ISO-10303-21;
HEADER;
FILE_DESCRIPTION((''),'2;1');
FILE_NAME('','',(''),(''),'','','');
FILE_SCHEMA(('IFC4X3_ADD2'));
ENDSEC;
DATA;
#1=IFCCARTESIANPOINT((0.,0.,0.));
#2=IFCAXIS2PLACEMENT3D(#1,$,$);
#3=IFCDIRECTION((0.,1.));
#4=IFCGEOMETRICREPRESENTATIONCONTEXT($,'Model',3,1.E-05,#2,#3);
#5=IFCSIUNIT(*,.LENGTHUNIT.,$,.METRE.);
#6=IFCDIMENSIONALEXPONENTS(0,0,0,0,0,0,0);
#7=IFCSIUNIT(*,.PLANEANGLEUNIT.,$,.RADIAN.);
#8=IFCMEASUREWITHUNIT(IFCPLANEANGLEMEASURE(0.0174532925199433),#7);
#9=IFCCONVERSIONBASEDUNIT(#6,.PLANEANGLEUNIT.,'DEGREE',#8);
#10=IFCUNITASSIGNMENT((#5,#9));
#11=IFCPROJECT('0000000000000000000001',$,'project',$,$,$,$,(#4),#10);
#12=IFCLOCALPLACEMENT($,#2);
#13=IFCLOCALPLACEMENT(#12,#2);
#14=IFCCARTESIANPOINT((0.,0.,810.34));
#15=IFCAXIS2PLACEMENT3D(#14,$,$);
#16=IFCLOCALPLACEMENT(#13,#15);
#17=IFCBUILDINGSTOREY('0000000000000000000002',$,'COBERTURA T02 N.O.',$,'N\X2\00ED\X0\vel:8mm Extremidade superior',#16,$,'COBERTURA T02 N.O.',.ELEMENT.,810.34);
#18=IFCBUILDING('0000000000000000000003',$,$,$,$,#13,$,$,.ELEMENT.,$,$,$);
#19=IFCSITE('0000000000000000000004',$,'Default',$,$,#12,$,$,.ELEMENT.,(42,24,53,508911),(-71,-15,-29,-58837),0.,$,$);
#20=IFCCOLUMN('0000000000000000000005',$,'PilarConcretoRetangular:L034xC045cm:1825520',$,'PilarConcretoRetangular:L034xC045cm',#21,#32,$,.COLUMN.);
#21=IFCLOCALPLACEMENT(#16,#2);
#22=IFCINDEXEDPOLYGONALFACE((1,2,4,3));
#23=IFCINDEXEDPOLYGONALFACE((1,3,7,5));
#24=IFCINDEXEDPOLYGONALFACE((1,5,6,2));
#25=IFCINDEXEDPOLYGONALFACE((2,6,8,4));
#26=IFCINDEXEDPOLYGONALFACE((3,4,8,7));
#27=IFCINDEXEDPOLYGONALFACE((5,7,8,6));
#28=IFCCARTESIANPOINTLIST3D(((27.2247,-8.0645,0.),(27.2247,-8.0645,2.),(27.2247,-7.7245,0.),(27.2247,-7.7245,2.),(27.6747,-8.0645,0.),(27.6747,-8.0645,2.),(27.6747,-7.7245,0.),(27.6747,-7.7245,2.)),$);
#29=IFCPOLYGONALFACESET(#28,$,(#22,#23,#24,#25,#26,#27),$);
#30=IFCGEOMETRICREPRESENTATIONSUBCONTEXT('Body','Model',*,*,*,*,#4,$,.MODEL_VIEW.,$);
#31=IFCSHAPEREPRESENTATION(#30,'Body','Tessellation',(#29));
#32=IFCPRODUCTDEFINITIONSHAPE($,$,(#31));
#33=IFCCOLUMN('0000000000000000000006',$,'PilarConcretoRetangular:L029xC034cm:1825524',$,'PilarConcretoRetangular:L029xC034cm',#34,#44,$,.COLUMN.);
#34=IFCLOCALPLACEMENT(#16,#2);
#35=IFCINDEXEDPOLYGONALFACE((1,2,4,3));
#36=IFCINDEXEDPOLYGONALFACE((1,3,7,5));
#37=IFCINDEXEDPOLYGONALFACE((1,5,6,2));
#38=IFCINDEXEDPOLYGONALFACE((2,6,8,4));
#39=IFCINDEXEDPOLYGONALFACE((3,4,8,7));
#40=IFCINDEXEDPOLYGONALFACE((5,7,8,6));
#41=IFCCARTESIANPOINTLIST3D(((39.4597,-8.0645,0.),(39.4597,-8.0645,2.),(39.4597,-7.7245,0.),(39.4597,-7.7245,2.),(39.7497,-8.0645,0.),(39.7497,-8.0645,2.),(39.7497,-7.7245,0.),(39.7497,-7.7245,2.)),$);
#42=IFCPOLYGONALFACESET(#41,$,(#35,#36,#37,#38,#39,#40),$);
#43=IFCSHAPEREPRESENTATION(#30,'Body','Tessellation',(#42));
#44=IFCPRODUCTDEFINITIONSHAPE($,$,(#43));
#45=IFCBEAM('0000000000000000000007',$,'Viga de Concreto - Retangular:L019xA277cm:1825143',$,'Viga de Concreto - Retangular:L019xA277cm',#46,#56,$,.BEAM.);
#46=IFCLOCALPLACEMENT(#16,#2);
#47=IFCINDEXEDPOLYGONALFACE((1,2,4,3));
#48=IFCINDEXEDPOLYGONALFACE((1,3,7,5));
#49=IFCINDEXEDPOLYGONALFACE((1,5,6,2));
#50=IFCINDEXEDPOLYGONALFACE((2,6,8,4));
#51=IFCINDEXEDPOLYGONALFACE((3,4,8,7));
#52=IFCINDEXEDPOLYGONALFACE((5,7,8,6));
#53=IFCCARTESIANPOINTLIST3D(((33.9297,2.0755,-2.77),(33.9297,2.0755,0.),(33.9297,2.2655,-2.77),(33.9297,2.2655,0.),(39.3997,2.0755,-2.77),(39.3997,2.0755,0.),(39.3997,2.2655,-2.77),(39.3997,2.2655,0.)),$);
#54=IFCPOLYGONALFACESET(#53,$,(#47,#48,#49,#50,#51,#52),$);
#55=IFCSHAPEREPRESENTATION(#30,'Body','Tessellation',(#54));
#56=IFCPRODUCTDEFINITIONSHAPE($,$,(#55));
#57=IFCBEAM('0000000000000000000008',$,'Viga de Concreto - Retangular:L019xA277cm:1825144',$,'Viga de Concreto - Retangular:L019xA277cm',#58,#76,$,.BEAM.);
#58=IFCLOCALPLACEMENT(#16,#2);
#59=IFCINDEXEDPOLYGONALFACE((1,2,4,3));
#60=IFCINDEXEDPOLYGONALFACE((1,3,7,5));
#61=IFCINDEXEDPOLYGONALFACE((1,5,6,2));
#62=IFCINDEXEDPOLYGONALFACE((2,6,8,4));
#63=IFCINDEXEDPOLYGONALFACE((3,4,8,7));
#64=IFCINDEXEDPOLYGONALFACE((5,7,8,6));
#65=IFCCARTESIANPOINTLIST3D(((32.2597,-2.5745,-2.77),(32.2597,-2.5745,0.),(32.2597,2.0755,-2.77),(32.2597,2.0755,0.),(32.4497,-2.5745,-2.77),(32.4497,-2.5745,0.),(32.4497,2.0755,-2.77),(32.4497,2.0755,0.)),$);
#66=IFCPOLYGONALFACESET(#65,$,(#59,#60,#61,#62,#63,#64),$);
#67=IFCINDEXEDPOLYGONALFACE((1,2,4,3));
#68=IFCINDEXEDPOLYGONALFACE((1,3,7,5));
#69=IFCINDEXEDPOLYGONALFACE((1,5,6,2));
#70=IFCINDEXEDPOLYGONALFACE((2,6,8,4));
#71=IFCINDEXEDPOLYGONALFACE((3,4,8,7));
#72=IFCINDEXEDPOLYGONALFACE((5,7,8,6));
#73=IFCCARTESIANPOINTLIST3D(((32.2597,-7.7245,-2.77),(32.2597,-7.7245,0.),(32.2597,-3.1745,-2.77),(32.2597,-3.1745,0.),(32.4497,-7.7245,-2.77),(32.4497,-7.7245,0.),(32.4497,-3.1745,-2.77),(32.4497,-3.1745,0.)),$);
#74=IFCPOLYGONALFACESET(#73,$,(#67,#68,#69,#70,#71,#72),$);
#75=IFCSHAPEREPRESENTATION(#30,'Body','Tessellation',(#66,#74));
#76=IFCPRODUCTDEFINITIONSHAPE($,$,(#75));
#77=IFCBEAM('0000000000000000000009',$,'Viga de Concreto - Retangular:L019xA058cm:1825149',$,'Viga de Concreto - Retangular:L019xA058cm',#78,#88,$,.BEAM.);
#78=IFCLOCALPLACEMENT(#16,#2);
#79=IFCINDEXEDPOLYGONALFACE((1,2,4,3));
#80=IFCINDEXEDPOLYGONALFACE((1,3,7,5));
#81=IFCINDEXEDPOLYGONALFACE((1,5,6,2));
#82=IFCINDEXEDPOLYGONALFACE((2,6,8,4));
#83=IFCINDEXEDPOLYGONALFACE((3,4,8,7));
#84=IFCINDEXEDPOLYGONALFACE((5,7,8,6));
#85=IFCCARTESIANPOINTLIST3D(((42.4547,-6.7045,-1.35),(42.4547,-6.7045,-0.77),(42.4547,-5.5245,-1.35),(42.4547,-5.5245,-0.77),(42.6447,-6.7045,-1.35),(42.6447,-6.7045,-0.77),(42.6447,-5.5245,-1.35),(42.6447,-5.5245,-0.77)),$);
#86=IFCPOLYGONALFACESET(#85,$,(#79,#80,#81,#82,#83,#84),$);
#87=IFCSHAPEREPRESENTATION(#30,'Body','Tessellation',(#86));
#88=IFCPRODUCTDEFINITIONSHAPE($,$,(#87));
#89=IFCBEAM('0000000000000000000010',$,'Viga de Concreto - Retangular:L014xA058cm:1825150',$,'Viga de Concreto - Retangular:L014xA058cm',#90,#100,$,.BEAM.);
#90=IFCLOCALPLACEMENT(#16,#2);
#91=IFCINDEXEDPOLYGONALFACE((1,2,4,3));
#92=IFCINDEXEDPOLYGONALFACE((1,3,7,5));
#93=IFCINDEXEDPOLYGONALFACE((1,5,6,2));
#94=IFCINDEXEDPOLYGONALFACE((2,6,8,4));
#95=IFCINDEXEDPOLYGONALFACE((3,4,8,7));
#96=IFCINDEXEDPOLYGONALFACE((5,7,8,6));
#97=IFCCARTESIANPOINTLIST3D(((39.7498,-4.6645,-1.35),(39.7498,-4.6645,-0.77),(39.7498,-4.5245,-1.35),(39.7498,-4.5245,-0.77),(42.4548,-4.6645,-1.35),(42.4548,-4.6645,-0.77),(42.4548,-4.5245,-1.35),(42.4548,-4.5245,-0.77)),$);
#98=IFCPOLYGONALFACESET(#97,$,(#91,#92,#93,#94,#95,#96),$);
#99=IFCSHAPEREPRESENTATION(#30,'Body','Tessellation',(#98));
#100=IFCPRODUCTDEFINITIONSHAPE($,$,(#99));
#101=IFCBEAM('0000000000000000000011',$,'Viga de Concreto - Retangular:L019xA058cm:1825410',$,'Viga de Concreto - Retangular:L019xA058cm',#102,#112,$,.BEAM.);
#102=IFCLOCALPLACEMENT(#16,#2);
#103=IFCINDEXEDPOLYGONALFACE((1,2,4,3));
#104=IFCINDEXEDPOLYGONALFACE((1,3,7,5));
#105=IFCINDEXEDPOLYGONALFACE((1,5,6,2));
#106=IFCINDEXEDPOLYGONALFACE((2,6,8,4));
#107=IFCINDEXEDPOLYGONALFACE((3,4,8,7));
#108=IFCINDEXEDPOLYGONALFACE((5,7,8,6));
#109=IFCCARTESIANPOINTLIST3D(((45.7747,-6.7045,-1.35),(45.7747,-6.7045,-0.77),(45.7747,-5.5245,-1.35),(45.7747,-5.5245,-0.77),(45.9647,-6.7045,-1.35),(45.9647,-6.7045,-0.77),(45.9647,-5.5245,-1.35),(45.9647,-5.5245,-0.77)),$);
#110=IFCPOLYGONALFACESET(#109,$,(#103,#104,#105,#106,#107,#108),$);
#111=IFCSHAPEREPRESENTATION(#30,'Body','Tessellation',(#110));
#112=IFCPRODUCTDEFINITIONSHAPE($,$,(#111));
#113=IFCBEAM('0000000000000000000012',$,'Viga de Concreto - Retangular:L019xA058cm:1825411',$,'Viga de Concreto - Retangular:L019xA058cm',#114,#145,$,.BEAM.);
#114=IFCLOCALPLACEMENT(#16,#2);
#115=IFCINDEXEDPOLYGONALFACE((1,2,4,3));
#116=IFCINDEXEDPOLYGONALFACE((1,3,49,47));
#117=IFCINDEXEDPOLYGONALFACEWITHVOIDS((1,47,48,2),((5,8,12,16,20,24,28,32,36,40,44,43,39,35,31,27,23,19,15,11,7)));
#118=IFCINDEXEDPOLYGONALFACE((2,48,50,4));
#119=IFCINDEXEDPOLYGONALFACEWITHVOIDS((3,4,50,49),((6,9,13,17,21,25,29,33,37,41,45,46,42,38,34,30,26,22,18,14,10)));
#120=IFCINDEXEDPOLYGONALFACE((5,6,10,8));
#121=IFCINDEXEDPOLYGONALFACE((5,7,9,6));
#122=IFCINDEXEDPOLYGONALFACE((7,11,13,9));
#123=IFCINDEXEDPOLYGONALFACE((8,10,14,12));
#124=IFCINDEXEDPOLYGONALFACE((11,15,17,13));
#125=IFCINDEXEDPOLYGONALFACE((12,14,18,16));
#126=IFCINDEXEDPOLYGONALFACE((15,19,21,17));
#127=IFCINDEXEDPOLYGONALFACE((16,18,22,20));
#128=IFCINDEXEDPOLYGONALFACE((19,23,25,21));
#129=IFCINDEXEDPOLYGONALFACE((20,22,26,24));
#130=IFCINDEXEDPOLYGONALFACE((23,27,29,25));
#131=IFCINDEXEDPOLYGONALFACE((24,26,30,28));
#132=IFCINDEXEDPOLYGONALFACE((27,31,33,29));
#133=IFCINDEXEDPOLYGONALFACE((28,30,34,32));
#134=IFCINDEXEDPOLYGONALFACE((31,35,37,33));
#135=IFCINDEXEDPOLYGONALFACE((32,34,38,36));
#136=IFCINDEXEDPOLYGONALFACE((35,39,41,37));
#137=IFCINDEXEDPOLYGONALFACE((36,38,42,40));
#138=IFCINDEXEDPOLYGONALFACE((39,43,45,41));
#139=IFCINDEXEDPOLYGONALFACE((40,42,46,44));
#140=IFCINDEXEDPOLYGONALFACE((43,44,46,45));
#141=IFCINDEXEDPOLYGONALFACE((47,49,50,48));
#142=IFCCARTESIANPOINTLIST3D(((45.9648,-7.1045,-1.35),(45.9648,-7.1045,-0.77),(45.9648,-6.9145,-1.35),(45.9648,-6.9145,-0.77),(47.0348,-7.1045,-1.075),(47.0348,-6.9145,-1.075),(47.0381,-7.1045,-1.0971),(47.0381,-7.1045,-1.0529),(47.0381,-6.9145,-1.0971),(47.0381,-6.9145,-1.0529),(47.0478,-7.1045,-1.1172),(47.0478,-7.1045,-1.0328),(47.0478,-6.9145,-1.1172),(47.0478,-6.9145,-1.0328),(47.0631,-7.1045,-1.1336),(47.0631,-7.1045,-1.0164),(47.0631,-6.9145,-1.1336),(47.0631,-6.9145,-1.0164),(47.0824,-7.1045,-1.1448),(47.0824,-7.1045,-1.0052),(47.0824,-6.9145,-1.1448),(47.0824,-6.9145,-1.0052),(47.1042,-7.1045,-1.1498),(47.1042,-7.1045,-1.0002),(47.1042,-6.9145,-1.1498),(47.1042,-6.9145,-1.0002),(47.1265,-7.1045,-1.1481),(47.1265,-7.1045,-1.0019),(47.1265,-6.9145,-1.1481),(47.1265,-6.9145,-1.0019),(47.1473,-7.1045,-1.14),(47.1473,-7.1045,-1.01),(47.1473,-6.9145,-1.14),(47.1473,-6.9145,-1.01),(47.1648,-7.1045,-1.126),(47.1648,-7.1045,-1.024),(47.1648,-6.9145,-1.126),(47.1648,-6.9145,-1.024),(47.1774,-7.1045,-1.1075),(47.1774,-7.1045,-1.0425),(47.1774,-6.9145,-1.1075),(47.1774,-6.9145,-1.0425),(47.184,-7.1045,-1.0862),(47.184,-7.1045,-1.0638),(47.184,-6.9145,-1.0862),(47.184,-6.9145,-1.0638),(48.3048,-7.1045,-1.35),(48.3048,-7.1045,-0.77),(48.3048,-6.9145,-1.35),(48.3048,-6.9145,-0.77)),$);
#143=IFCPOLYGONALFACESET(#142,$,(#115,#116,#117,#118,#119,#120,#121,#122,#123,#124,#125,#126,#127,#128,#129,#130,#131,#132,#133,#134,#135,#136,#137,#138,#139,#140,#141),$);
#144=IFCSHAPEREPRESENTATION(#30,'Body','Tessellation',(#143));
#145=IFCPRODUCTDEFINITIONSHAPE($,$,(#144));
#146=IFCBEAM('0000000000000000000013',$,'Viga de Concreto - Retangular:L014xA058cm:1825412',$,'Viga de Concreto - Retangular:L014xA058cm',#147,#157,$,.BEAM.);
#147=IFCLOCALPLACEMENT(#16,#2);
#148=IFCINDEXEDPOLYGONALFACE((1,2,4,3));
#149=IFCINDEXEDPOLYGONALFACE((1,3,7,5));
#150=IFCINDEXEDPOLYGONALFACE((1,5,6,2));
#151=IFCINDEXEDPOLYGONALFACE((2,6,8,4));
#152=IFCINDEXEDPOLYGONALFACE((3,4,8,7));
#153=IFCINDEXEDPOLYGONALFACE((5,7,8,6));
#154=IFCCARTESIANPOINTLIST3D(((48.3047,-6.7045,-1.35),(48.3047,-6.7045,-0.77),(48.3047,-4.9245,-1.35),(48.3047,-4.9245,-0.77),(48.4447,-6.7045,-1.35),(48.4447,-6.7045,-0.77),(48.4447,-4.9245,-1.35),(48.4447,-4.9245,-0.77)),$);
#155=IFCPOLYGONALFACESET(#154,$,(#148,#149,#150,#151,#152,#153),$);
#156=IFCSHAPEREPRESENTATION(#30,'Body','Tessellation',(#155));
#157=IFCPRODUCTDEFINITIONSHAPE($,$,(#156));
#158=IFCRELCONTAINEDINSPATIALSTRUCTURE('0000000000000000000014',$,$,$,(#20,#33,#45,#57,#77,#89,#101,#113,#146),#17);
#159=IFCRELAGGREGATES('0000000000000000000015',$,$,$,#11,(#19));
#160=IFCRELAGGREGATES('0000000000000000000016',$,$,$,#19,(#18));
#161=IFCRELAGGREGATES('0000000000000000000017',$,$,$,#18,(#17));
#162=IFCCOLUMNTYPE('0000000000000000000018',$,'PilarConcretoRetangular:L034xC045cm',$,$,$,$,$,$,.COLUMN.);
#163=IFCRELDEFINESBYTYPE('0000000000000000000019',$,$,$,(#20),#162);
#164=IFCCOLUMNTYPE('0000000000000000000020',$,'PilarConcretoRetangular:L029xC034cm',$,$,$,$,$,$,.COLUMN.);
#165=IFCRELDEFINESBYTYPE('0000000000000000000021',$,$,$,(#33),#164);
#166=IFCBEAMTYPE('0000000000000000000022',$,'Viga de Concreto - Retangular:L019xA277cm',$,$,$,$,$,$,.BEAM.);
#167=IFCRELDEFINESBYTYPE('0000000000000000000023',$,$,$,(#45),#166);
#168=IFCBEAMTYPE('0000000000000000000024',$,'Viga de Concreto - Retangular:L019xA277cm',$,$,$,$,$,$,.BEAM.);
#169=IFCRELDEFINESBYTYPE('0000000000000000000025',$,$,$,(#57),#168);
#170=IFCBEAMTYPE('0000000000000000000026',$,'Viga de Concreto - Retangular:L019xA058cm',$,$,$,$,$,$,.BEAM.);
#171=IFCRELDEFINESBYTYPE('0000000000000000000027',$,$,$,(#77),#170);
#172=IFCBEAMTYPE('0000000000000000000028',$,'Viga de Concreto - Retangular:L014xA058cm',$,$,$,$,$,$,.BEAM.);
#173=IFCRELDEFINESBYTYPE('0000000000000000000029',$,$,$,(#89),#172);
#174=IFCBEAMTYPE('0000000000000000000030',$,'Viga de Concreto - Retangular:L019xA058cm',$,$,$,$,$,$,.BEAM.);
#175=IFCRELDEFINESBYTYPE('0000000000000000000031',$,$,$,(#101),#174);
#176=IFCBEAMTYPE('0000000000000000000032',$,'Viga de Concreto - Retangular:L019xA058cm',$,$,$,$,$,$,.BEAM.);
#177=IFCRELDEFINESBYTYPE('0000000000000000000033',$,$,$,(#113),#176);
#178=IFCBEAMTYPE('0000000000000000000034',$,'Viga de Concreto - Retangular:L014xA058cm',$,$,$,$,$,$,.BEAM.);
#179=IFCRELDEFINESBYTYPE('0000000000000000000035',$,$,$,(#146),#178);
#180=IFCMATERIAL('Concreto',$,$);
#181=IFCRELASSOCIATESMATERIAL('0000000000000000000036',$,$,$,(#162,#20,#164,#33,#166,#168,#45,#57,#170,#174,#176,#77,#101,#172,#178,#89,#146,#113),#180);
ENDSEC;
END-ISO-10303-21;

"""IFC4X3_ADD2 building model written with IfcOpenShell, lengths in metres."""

from ifc_helpers import new_model, entity, si_unit, converted_unit, direction, frame, frame_2d, origin, origin_2d_with_axis, place, context, subcontext, project, spatial, polyline, segment, composite_curve, rectangle, circle, outline, extrude, boolean, source, transform, mapped, material, material_profile, profile_set, profile_usage, type_object, type_shapes, element, save


model = new_model("IFC4X3_ADD2")

# Units and contexts
model_context = context("Model", 3, precision=1e-05, world=origin(), true_north=direction((0.0, 1.0)))
body_context = subcontext(model_context, "Body", "Model", "MODEL_VIEW")
ifc_project = project(units=[si_unit("LENGTHUNIT", "METRE"), converted_unit("PLANEANGLEUNIT", "DEGREE", entity("IfcPlaneAngleMeasure", 0.0174532925199433), si_unit("PLANEANGLEUNIT", "RADIAN"), dimensions=[0, 0, 0, 0, 0, 0, 0])], contexts=[model_context])

# Site, building, storey
site_placement = place(None, origin())
site = spatial("IfcSite", under=ifc_project, at=site_placement, Name="Default", CompositionType="ELEMENT", RefLatitude=(42, 24, 53, 508911), RefLongitude=(-71, -15, -29, -58837), RefElevation=0.0)
building_placement = place(site_placement, origin())
building = spatial("IfcBuilding", under=site, at=building_placement, CompositionType="ELEMENT")
storey_placement = place(building_placement, frame((0.0, 0.0, 810.34)))
storey = spatial("IfcBuildingStorey", under=building, at=storey_placement, Name="COBERTURA T02 N.O.", ObjectType="Nível:8mm Extremidade superior", LongName="COBERTURA T02 N.O.", CompositionType="ELEMENT", Elevation=810.34)

# Columns
ifc_material = material(Name="Concreto")
ifc_material_profile_1 = material_profile(ifc_material, rectangle(XDim=0.34, YDim=0.45, at=origin_2d_with_axis()), Name="L034xC045cm")
ifc_profile_set_1 = profile_set([ifc_material_profile_1], Name="L034xC045cm")
ifc_profile_usage_1 = profile_usage(ifc_profile_set_1)
column_type_1 = type_object("IfcColumnType", Name="PilarConcretoRetangular:L034xC045cm", PredefinedType="COLUMN", material=ifc_profile_set_1)
shared_shape_1 = source(origin(), body_context, "Body", "SweptSolid", [
    extrude(rectangle(XDim=0.34, YDim=0.45, at=origin_2d_with_axis()), frame((27.4497, -7.8945, 810.34), z_axis=(0.0, 0.0, 1.0), x_axis=(0.0, -1.0, 0.0)), (0.0, 0.0, 1.0), 2.0),
])
type_shapes(column_type_1, [shared_shape_1])
column_1_placement = place(storey_placement, frame((0.0, 0.0, -810.34)))
element("IfcColumn", 1, at=column_1_placement, inside=storey, type_object=column_type_1, material=ifc_profile_usage_1, Name="PilarConcretoRetangular:L034xC045cm:1825520", ObjectType="PilarConcretoRetangular:L034xC045cm", PredefinedType="COLUMN", context=body_context, shape_type="MappedRepresentation", body=[
    mapped(shared_shape_1, transform((0.0, 0.0, 0.0), scale=1.0)),
])
ifc_material_profile_2 = material_profile(ifc_material, rectangle(XDim=0.29, YDim=0.34, at=origin_2d_with_axis()), Name="L029xC034cm")
ifc_profile_set_2 = profile_set([ifc_material_profile_2], Name="L029xC034cm")
ifc_profile_usage_2 = profile_usage(ifc_profile_set_2)
column_type_2 = type_object("IfcColumnType", Name="PilarConcretoRetangular:L029xC034cm", PredefinedType="COLUMN", material=ifc_profile_set_2)
shared_shape_2 = source(origin(), body_context, "Body", "SweptSolid", [
    extrude(rectangle(XDim=0.29, YDim=0.34, at=origin_2d_with_axis()), frame((39.6047, -7.8945, 810.34)), (0.0, 0.0, 1.0), 2.0),
])
type_shapes(column_type_2, [shared_shape_2])
column_2_placement = place(storey_placement, frame((0.0, 0.0, -810.34)))
element("IfcColumn", 2, at=column_2_placement, inside=storey, type_object=column_type_2, material=ifc_profile_usage_2, Name="PilarConcretoRetangular:L029xC034cm:1825524", ObjectType="PilarConcretoRetangular:L029xC034cm", PredefinedType="COLUMN", context=body_context, shape_type="MappedRepresentation", body=[
    mapped(shared_shape_2, transform((0.0, 0.0, 0.0), scale=1.0)),
])

# Beams
ifc_material_profile_3 = material_profile(ifc_material, rectangle(XDim=2.77, YDim=0.19, at=origin_2d_with_axis()), Name="L019xA277cm")
ifc_profile_set_3 = profile_set([ifc_material_profile_3], Name="L019xA277cm")
ifc_profile_usage_3 = profile_usage(ifc_profile_set_3, cardinal=8)
beam_type_1 = type_object("IfcBeamType", Name="Viga de Concreto - Retangular:L019xA277cm", PredefinedType="BEAM", material=ifc_profile_set_3)
shared_shape_3 = source(origin(), body_context, "Body", "SweptSolid", [
    extrude(rectangle(XDim=2.77, YDim=0.19, at=origin_2d_with_axis()), frame((33.9297, 2.1705, 808.955), z_axis=(1.0, 0.0, 0.0), x_axis=(0.0, 0.0, -1.0)), (0.0, 0.0, 1.0), 5.47),
])
type_shapes(beam_type_1, [shared_shape_3])
beam_1_placement = place(storey_placement, frame((0.0, 0.0, -810.34)))
element("IfcBeam", 3, at=beam_1_placement, inside=storey, type_object=beam_type_1, material=ifc_profile_usage_3, Name="Viga de Concreto - Retangular:L019xA277cm:1825143", ObjectType="Viga de Concreto - Retangular:L019xA277cm", PredefinedType="BEAM", context=body_context, shape_type="MappedRepresentation", body=[
    mapped(shared_shape_3, transform((0.0, 0.0, 0.0), scale=1.0)),
])
beam_type_2 = type_object("IfcBeamType", Name="Viga de Concreto - Retangular:L019xA277cm", PredefinedType="BEAM", material=ifc_profile_set_3)
shared_shape_4 = source(origin(), body_context, "Body", "SweptSolid", [
    extrude(rectangle(XDim=2.77, YDim=0.19, at=frame_2d((0.0, 0.0), x_axis=(0.0, 1.0))), frame((32.3547, -2.5745, 808.955), z_axis=(0.0, 1.0, 0.0), x_axis=(-1.0, 0.0, 0.0)), (0.0, 0.0, 1.0), 4.65),
    extrude(rectangle(XDim=2.77, YDim=0.19, at=frame_2d((0.0, 0.0), x_axis=(0.0, 1.0))), frame((32.3547, -7.7245, 808.955), z_axis=(0.0, 1.0, 0.0), x_axis=(-1.0, 0.0, 0.0)), (0.0, 0.0, 1.0), 4.55),
])
type_shapes(beam_type_2, [shared_shape_4])
beam_2_placement = place(storey_placement, frame((0.0, 0.0, -810.34)))
element("IfcBeam", 4, at=beam_2_placement, inside=storey, type_object=beam_type_2, material=ifc_profile_usage_3, Name="Viga de Concreto - Retangular:L019xA277cm:1825144", ObjectType="Viga de Concreto - Retangular:L019xA277cm", PredefinedType="BEAM", context=body_context, shape_type="MappedRepresentation", body=[
    mapped(shared_shape_4, transform((0.0, 0.0, 0.0), scale=1.0)),
])
ifc_material_profile_4 = material_profile(ifc_material, outline(composite_curve([segment(polyline([(-0.095, 0.29, 0.0), (0.095, 0.29, 0.0)]), True, "CONTINUOUS"), segment(polyline([(0.095, 0.29, 0.0), (0.095, -0.29, 0.0)]), True, "CONTINUOUS"), segment(polyline([(0.095, -0.29, 0.0), (-0.095, -0.29, 0.0)]), True, "CONTINUOUS"), segment(polyline([(-0.095, -0.29, 0.0), (-0.095, 0.29, 0.0)]), True, "CONTINUOUS")], self_intersect=False), kind="CURVE"), Name="L019xA058cm")
ifc_material_profile_5 = material_profile(ifc_material, outline(composite_curve([segment(polyline([(1.4475, 0.095, 0.29), (1.4475, -0.095, 0.29)]), True, "CONTINUOUS"), segment(polyline([(1.4475, -0.095, 0.29), (1.4475, -0.095, -0.29)]), True, "CONTINUOUS"), segment(polyline([(1.4475, -0.095, -0.29), (1.4475, 0.095, -0.29)]), True, "CONTINUOUS"), segment(polyline([(1.4475, 0.095, -0.29), (1.4475, 0.095, 0.29)]), True, "CONTINUOUS")], self_intersect=False), kind="CURVE"), Name="L019xA058cm")
ifc_profile_set_4 = profile_set([ifc_material_profile_4, ifc_material_profile_5], Name="L019xA058cm")
ifc_profile_usage_4 = profile_usage(ifc_profile_set_4, cardinal=8)
beam_type_3 = type_object("IfcBeamType", Name="Viga de Concreto - Retangular:L019xA058cm", PredefinedType="BEAM", material=ifc_profile_set_4)
shared_shape_5 = source(origin(), body_context, "Body", "SweptSolid", [
    extrude(rectangle(XDim=0.58, YDim=0.19, at=frame_2d((0.0, 0.0), x_axis=(0.0, 1.0))), frame((42.5497, -6.7045, 809.28), z_axis=(0.0, 1.0, 0.0), x_axis=(-1.0, 0.0, 0.0)), (0.0, 0.0, 1.0), 1.18),
])
type_shapes(beam_type_3, [shared_shape_5])
beam_3_placement = place(storey_placement, frame((0.0, 0.0, -810.34)))
element("IfcBeam", 5, at=beam_3_placement, inside=storey, type_object=beam_type_3, material=ifc_profile_usage_4, Name="Viga de Concreto - Retangular:L019xA058cm:1825149", ObjectType="Viga de Concreto - Retangular:L019xA058cm", PredefinedType="BEAM", context=body_context, shape_type="MappedRepresentation", body=[
    mapped(shared_shape_5, transform((0.0, 0.0, 0.0), scale=1.0)),
])
ifc_material_profile_6 = material_profile(ifc_material, rectangle(XDim=0.58, YDim=0.14, at=frame_2d((0.0, 0.0), x_axis=(1.0, 0.0))), Name="L014xA058cm")
ifc_profile_set_5 = profile_set([ifc_material_profile_6], Name="L014xA058cm")
ifc_profile_usage_5 = profile_usage(ifc_profile_set_5, cardinal=8)
beam_type_4 = type_object("IfcBeamType", Name="Viga de Concreto - Retangular:L014xA058cm", PredefinedType="BEAM", material=ifc_profile_set_5)
shared_shape_6 = source(origin(), body_context, "Body", "SweptSolid", [
    extrude(rectangle(XDim=0.58, YDim=0.14, at=frame_2d((0.0, 0.0), x_axis=(1.0, 0.0))), frame((42.4548, -4.5945, 809.28), z_axis=(-1.0, 0.0, 0.0), x_axis=(0.0, 0.0, -1.0)), (0.0, 0.0, 1.0), 2.705),
])
type_shapes(beam_type_4, [shared_shape_6])
beam_4_placement = place(storey_placement, frame((0.0, 0.0, -810.34)))
element("IfcBeam", 6, at=beam_4_placement, inside=storey, type_object=beam_type_4, material=ifc_profile_usage_5, Name="Viga de Concreto - Retangular:L014xA058cm:1825150", ObjectType="Viga de Concreto - Retangular:L014xA058cm", PredefinedType="BEAM", context=body_context, shape_type="MappedRepresentation", body=[
    mapped(shared_shape_6, transform((0.0, 0.0, 0.0), scale=1.0)),
])
beam_type_5 = type_object("IfcBeamType", Name="Viga de Concreto - Retangular:L019xA058cm", PredefinedType="BEAM", material=ifc_profile_set_4)
shared_shape_7 = source(origin(), body_context, "Body", "SweptSolid", [
    extrude(rectangle(XDim=0.58, YDim=0.19, at=frame_2d((0.0, 0.0), x_axis=(0.0, 1.0))), frame((45.8697, -6.7045, 809.28), z_axis=(0.0, 1.0, 0.0), x_axis=(-1.0, 0.0, 0.0)), (0.0, 0.0, 1.0), 1.18),
])
type_shapes(beam_type_5, [shared_shape_7])
beam_5_placement = place(storey_placement, frame((0.0, 0.0, -810.34)))
element("IfcBeam", 7, at=beam_5_placement, inside=storey, type_object=beam_type_5, material=ifc_profile_usage_4, Name="Viga de Concreto - Retangular:L019xA058cm:1825410", ObjectType="Viga de Concreto - Retangular:L019xA058cm", PredefinedType="BEAM", context=body_context, shape_type="MappedRepresentation", body=[
    mapped(shared_shape_7, transform((0.0, 0.0, 0.0), scale=1.0)),
])
beam_type_6 = type_object("IfcBeamType", Name="Viga de Concreto - Retangular:L019xA058cm", PredefinedType="BEAM", material=ifc_profile_set_4)
shared_shape_8 = source(origin(), body_context, "Body", "CSG", [
    boolean("DIFFERENCE", extrude(rectangle(XDim=0.58, YDim=0.19, at=frame_2d((0.0, 0.0), x_axis=(0.0, 1.0))), frame((45.9648, -7.0095, 809.28), z_axis=(1.0, 0.0, 0.0), x_axis=(0.0, 1.0, 0.0)), (0.0, 0.0, 1.0), 2.34), extrude(circle(Radius=0.075, at=origin_2d_with_axis()), frame((47.1098, -6.9145, 809.265), z_axis=(0.0, -1.0, 0.0), x_axis=(-1.0, 0.0, 0.0)), (0.0, 0.0, 1.0), 0.19)),
])
type_shapes(beam_type_6, [shared_shape_8])
beam_6_placement = place(storey_placement, frame((0.0, 0.0, -810.34)))
element("IfcBeam", 8, at=beam_6_placement, inside=storey, type_object=beam_type_6, material=ifc_material, Name="Viga de Concreto - Retangular:L019xA058cm:1825411", ObjectType="Viga de Concreto - Retangular:L019xA058cm", PredefinedType="BEAM", context=body_context, shape_type="MappedRepresentation", body=[
    mapped(shared_shape_8, transform((0.0, 0.0, 0.0), scale=1.0)),
])
beam_type_7 = type_object("IfcBeamType", Name="Viga de Concreto - Retangular:L014xA058cm", PredefinedType="BEAM", material=ifc_profile_set_5)
shared_shape_9 = source(origin(), body_context, "Body", "SweptSolid", [
    extrude(rectangle(XDim=0.58, YDim=0.14, at=frame_2d((0.0, 0.0), x_axis=(0.0, 1.0))), frame((48.3747, -6.7045, 809.28), z_axis=(0.0, 1.0, 0.0), x_axis=(-1.0, 0.0, 0.0)), (0.0, 0.0, 1.0), 1.78),
])
type_shapes(beam_type_7, [shared_shape_9])
beam_7_placement = place(storey_placement, frame((0.0, 0.0, -810.34)))
element("IfcBeam", 9, at=beam_7_placement, inside=storey, type_object=beam_type_7, material=ifc_profile_usage_5, Name="Viga de Concreto - Retangular:L014xA058cm:1825412", ObjectType="Viga de Concreto - Retangular:L014xA058cm", PredefinedType="BEAM", context=body_context, shape_type="MappedRepresentation", body=[
    mapped(shared_shape_9, transform((0.0, 0.0, 0.0), scale=1.0)),
])

save(model, "model.ifc")
